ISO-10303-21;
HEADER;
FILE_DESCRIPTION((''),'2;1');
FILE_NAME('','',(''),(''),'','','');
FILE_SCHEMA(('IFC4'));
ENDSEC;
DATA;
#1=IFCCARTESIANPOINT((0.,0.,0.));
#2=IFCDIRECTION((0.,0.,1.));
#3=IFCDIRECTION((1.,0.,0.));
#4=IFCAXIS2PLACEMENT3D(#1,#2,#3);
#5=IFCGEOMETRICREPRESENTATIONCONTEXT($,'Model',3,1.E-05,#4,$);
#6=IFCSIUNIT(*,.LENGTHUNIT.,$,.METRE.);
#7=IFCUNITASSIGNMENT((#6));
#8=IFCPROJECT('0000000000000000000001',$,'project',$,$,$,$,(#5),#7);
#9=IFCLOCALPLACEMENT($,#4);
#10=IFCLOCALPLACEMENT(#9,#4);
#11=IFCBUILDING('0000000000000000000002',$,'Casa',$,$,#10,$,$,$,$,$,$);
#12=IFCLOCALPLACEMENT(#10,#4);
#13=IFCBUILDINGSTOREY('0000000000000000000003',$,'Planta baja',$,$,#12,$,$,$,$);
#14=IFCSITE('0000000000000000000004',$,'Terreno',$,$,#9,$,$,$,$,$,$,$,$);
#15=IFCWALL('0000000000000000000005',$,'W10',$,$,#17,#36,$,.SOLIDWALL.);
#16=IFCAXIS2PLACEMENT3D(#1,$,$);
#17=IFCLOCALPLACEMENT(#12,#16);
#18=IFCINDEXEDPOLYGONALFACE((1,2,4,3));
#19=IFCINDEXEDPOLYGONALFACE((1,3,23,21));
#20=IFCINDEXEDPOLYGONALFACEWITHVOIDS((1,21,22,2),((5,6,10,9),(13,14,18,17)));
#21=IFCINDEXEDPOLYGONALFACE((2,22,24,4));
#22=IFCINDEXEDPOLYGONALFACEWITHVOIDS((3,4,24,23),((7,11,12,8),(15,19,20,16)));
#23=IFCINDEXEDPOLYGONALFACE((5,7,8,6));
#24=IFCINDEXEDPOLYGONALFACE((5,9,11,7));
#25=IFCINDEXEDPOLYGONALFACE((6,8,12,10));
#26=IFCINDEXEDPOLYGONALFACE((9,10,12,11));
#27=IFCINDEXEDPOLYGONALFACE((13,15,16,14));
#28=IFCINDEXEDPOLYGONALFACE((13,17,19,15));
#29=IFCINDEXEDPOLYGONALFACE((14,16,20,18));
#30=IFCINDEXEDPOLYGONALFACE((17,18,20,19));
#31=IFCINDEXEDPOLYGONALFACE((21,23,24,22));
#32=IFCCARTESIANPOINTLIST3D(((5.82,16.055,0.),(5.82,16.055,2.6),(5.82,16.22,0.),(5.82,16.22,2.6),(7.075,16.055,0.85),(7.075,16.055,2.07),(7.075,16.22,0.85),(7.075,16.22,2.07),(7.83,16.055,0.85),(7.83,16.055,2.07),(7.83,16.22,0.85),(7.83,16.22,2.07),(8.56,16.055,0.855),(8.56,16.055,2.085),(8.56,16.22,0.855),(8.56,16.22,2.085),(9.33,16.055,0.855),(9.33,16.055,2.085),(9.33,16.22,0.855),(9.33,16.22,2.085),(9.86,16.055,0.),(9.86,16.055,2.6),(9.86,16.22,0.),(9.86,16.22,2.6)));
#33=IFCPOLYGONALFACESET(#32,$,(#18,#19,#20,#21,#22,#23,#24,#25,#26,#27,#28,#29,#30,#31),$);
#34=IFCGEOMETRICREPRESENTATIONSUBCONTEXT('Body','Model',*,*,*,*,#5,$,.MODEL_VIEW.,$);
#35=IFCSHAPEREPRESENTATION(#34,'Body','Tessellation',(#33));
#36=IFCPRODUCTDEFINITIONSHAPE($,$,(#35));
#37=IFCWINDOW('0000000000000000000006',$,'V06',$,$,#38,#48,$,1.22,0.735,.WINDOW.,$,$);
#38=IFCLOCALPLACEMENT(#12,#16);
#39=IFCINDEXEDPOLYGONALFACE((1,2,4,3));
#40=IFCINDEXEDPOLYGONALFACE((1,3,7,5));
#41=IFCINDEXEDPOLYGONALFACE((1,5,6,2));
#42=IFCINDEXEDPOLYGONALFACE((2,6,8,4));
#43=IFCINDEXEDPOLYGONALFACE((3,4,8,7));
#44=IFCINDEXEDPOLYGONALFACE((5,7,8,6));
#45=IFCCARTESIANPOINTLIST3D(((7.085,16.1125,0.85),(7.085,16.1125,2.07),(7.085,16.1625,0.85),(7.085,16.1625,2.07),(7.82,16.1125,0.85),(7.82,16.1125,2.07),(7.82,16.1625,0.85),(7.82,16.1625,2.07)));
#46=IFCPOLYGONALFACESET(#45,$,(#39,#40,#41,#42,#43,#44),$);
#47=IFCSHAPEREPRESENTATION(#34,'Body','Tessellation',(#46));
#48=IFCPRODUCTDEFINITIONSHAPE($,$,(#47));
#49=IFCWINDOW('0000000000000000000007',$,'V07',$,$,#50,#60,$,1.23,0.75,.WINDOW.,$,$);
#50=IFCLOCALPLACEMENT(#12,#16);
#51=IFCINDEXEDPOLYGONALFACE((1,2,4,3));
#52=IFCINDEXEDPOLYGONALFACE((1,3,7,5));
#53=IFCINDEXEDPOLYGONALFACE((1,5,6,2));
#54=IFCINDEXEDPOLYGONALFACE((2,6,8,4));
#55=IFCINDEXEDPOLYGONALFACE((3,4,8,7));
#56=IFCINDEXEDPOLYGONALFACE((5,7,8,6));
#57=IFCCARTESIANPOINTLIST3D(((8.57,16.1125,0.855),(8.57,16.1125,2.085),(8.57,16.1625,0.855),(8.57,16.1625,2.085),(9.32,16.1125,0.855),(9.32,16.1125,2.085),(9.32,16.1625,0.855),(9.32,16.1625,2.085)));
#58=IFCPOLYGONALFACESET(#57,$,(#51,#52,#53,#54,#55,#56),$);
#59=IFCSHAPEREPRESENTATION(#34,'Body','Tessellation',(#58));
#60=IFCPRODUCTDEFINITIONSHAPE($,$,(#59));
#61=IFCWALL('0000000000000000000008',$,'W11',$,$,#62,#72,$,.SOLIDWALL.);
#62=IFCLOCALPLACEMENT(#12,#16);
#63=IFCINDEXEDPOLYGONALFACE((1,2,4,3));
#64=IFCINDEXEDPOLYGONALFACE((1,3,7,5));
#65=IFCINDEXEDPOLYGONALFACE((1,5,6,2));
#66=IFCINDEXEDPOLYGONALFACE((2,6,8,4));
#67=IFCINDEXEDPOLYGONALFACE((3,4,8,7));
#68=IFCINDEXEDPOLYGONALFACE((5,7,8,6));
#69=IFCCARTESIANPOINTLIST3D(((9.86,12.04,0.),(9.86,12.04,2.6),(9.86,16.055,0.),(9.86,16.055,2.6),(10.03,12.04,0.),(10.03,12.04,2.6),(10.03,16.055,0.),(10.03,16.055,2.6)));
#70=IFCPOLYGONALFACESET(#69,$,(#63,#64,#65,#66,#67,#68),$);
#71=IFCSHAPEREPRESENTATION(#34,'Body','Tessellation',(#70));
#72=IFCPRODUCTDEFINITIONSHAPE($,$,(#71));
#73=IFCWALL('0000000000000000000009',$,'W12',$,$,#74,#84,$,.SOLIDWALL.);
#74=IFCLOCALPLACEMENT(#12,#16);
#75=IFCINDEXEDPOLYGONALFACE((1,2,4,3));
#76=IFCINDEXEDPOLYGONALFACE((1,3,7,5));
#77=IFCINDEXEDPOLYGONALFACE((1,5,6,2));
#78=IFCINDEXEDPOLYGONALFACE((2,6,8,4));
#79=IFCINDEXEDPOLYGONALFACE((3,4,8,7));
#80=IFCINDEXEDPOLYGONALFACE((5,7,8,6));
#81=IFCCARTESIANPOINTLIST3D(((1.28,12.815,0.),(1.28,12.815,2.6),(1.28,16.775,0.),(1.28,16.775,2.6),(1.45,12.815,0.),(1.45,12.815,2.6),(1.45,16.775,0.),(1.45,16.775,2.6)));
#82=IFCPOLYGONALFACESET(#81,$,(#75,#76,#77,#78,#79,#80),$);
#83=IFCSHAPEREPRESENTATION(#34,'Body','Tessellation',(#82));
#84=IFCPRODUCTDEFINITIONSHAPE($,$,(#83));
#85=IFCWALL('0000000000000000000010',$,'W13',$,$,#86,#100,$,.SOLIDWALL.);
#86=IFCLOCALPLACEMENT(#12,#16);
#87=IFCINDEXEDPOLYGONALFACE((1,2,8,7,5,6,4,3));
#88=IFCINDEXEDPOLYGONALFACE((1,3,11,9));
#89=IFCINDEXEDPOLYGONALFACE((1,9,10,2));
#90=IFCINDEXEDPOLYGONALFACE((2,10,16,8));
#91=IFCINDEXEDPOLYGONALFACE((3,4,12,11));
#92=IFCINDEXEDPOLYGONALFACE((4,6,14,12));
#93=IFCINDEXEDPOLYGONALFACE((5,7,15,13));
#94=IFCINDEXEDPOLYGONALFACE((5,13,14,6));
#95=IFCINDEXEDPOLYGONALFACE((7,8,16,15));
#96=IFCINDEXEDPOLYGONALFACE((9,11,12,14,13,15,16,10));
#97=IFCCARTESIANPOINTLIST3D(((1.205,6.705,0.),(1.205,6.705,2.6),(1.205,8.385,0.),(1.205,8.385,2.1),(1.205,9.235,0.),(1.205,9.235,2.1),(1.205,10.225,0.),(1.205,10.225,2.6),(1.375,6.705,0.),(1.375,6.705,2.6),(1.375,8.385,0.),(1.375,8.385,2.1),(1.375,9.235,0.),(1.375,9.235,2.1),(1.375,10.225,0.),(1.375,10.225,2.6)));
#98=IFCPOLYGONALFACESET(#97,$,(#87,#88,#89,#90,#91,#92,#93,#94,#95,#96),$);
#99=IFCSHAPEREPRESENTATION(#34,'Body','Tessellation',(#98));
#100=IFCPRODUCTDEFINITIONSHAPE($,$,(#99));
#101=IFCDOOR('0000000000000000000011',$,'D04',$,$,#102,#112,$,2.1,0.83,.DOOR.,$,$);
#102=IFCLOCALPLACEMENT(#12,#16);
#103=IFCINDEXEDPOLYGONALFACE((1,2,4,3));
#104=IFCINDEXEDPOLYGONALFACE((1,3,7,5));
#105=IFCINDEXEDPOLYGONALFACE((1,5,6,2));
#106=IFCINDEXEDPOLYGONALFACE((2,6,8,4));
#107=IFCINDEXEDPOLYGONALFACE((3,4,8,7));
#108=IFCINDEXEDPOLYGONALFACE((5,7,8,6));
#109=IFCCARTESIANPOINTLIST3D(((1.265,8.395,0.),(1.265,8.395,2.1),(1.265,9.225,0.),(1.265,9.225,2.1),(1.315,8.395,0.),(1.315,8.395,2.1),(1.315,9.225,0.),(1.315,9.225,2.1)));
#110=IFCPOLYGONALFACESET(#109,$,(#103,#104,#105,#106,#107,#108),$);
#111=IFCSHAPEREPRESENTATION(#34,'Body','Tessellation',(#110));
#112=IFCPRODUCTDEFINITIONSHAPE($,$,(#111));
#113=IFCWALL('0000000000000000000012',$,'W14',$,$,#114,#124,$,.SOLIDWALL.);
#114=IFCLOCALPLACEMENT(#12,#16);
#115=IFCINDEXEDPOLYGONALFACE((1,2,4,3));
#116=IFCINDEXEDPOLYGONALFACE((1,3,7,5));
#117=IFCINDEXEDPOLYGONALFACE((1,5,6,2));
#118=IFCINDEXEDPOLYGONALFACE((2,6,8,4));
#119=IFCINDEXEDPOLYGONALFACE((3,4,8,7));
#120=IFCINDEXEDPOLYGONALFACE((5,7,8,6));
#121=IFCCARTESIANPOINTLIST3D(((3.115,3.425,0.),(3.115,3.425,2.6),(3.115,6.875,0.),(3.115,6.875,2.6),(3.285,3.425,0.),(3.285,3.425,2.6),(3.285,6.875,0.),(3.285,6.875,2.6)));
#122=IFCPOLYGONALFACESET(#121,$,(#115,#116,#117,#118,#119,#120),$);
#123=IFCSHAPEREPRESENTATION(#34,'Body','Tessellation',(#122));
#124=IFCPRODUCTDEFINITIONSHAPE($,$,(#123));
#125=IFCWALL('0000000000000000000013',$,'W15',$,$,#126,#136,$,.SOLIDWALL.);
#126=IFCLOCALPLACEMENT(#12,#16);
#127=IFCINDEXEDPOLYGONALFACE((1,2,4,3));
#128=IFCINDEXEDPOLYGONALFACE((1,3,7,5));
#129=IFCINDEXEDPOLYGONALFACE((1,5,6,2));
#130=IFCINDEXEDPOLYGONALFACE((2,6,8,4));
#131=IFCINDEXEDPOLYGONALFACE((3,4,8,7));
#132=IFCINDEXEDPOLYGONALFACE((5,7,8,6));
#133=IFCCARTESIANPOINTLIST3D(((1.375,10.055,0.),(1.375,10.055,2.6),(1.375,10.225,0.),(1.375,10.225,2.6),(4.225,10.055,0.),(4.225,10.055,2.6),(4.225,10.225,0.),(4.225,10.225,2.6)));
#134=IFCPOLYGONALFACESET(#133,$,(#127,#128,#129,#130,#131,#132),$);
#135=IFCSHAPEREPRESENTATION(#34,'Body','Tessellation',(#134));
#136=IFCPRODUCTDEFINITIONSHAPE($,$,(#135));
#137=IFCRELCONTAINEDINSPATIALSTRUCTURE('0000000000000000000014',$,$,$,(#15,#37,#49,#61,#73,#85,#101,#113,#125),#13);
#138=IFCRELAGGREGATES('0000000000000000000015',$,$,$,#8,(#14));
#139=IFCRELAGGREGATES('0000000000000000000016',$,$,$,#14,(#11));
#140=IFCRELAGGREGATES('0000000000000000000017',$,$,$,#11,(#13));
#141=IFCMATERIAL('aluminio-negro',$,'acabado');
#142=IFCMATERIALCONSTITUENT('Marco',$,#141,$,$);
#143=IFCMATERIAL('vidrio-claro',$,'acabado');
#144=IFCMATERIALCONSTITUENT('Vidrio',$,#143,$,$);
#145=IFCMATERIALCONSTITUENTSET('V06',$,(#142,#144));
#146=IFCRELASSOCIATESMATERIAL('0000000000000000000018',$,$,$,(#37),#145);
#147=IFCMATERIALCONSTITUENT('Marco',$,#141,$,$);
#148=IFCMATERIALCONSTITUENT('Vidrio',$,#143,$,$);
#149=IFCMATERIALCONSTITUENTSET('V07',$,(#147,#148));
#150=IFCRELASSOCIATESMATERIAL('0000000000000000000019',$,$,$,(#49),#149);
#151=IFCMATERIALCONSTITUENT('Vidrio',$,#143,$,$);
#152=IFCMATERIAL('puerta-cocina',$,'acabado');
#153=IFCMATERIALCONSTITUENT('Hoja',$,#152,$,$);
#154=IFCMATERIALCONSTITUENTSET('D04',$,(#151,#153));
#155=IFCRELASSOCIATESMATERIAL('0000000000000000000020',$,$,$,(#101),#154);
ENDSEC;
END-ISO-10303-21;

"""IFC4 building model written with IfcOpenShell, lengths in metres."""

from ifc_helpers import new_model, si_unit, frame, origin_with_axes, place, context, subcontext, project, spatial, line, indexed_curve, outline, extrude, material, constituent, constituent_set, element, fill, save


model = new_model("IFC4")

# Units and contexts
model_context = context("Model", 3, precision=1e-05, world=origin_with_axes())
body_context = subcontext(model_context, "Body", "Model", "MODEL_VIEW")
ifc_project = project(units=[si_unit("LENGTHUNIT", "METRE")], contexts=[model_context])

# Site, building, storey
site_placement = place(None, origin_with_axes())
site = spatial("IfcSite", under=ifc_project, at=site_placement, Name="Terreno")
building_placement = place(site_placement, origin_with_axes())
building = spatial("IfcBuilding", under=site, at=building_placement, Name="Casa")
storey_placement = place(building_placement, origin_with_axes())
storey = spatial("IfcBuildingStorey", under=building, at=storey_placement, Name="Planta baja")

# Shared definitions
ifc_material_1 = material(Name="aluminio-negro", Category="acabado")
ifc_material_2 = material(Name="vidrio-claro", Category="acabado")

# Wall, openings, windows
wall_1_placement = place(storey_placement, origin_with_axes())
wall_1 = element("IfcWall", 1, at=wall_1_placement, inside=storey, Name="W10", PredefinedType="SOLIDWALL", context=body_context, shape_type="SweptSolid", body=[
    extrude(outline(indexed_curve([(5.82, 16.055), (5.82, 16.22), (9.86, 16.22), (9.86, 16.055)], segments=[line(1, 2, 3, 4, 1)])), origin_with_axes(), (0.0, 0.0, 1.0), 2.6),
])
opening_1_placement = place(wall_1_placement, origin_with_axes())
opening_1 = element("IfcOpeningElement", 2, at=opening_1_placement, cuts=wall_1, PredefinedType="OPENING", context=body_context, shape_type="SweptSolid", body=[
    extrude(outline(indexed_curve([(7.075, 16.045), (7.83, 16.045), (7.83, 16.23), (7.075, 16.23)], segments=[line(1, 2, 3, 4, 1)])), frame((0.0, 0.0, 0.85), z_axis=(0.0, 0.0, 1.0), x_axis=(1.0, 0.0, 0.0)), (0.0, 0.0, 1.0), 1.22),
])
opening_2_placement = place(wall_1_placement, origin_with_axes())
opening_2 = element("IfcOpeningElement", 3, at=opening_2_placement, cuts=wall_1, PredefinedType="OPENING", context=body_context, shape_type="SweptSolid", body=[
    extrude(outline(indexed_curve([(8.56, 16.045), (9.33, 16.045), (9.33, 16.23), (8.56, 16.23)], segments=[line(1, 2, 3, 4, 1)])), frame((0.0, 0.0, 0.855), z_axis=(0.0, 0.0, 1.0), x_axis=(1.0, 0.0, 0.0)), (0.0, 0.0, 1.0), 1.23),
])
ifc_constituent_1 = constituent(ifc_material_1, Name="Marco")
ifc_constituent_2 = constituent(ifc_material_2, Name="Vidrio")
ifc_constituent_set_1 = constituent_set(constituents=[ifc_constituent_1, ifc_constituent_2], Name="V06")
window_1_placement = place(opening_1_placement, origin_with_axes())
window_1 = element("IfcWindow", 4, at=window_1_placement, inside=storey, material=ifc_constituent_set_1, Name="V06", OverallHeight=1.22, OverallWidth=0.735, PredefinedType="WINDOW", context=body_context, shape_type="SweptSolid", body=[
    extrude(outline(indexed_curve([(7.085, 16.1125), (7.82, 16.1125), (7.82, 16.1625), (7.085, 16.1625)], segments=[line(1, 2, 3, 4, 1)])), frame((0.0, 0.0, 0.85), z_axis=(0.0, 0.0, 1.0), x_axis=(1.0, 0.0, 0.0)), (0.0, 0.0, 1.0), 1.22),
])
fill(opening_1, window_1)
ifc_constituent_3 = constituent(ifc_material_1, Name="Marco")
ifc_constituent_4 = constituent(ifc_material_2, Name="Vidrio")
ifc_constituent_set_2 = constituent_set(constituents=[ifc_constituent_3, ifc_constituent_4], Name="V07")
window_2_placement = place(opening_2_placement, origin_with_axes())
window_2 = element("IfcWindow", 5, at=window_2_placement, inside=storey, material=ifc_constituent_set_2, Name="V07", OverallHeight=1.23, OverallWidth=0.75, PredefinedType="WINDOW", context=body_context, shape_type="SweptSolid", body=[
    extrude(outline(indexed_curve([(8.57, 16.1125), (9.32, 16.1125), (9.32, 16.1625), (8.57, 16.1625)], segments=[line(1, 2, 3, 4, 1)])), frame((0.0, 0.0, 0.855), z_axis=(0.0, 0.0, 1.0), x_axis=(1.0, 0.0, 0.0)), (0.0, 0.0, 1.0), 1.23),
])
fill(opening_2, window_2)

# Walls
wall_2_placement = place(storey_placement, origin_with_axes())
element("IfcWall", 6, at=wall_2_placement, inside=storey, Name="W11", PredefinedType="SOLIDWALL", context=body_context, shape_type="SweptSolid", body=[
    extrude(outline(indexed_curve([(9.86, 12.04), (9.86, 16.055), (10.03, 16.055), (10.03, 12.04)], segments=[line(1, 2, 3, 4, 1)])), origin_with_axes(), (0.0, 0.0, 1.0), 2.6),
])
wall_3_placement = place(storey_placement, origin_with_axes())
element("IfcWall", 7, at=wall_3_placement, inside=storey, Name="W12", PredefinedType="SOLIDWALL", context=body_context, shape_type="SweptSolid", body=[
    extrude(outline(indexed_curve([(1.28, 16.775), (1.45, 16.775), (1.45, 12.815), (1.28, 12.815)], segments=[line(1, 2, 3, 4, 1)])), origin_with_axes(), (0.0, 0.0, 1.0), 2.6),
])

# Wall, opening, door
wall_4_placement = place(storey_placement, origin_with_axes())
wall_4 = element("IfcWall", 8, at=wall_4_placement, inside=storey, Name="W13", PredefinedType="SOLIDWALL", context=body_context, shape_type="SweptSolid", body=[
    extrude(outline(indexed_curve([(1.375, 6.705), (1.205, 6.705), (1.205, 10.225), (1.375, 10.225)], segments=[line(1, 2, 3, 4, 1)])), origin_with_axes(), (0.0, 0.0, 1.0), 2.6),
])
opening_3_placement = place(wall_4_placement, origin_with_axes())
opening_3 = element("IfcOpeningElement", 9, at=opening_3_placement, cuts=wall_4, PredefinedType="OPENING", context=body_context, shape_type="SweptSolid", body=[
    extrude(outline(indexed_curve([(1.195, 8.385), (1.195, 9.235), (1.385, 9.235), (1.385, 8.385)], segments=[line(1, 2, 3, 4, 1)])), origin_with_axes(), (0.0, 0.0, 1.0), 2.1),
])
ifc_constituent_5 = constituent(ifc_material_2, Name="Vidrio")
ifc_material_3 = material(Name="puerta-cocina", Category="acabado")
ifc_constituent_6 = constituent(ifc_material_3, Name="Hoja")
ifc_constituent_set_3 = constituent_set(constituents=[ifc_constituent_5, ifc_constituent_6], Name="D04")
door_1_placement = place(opening_3_placement, origin_with_axes())
door_1 = element("IfcDoor", 10, at=door_1_placement, inside=storey, material=ifc_constituent_set_3, Name="D04", OverallHeight=2.1, OverallWidth=0.83, PredefinedType="DOOR", context=body_context, shape_type="SweptSolid", body=[
    extrude(outline(indexed_curve([(1.265, 8.395), (1.265, 9.225), (1.315, 9.225), (1.315, 8.395)], segments=[line(1, 2, 3, 4, 1)])), origin_with_axes(), (0.0, 0.0, 1.0), 2.1),
])
fill(opening_3, door_1)

# Walls
wall_5_placement = place(storey_placement, origin_with_axes())
element("IfcWall", 11, at=wall_5_placement, inside=storey, Name="W14", PredefinedType="SOLIDWALL", context=body_context, shape_type="SweptSolid", body=[
    extrude(outline(indexed_curve([(3.285, 3.425), (3.115, 3.425), (3.115, 6.875), (3.285, 6.875)], segments=[line(1, 2, 3, 4, 1)])), origin_with_axes(), (0.0, 0.0, 1.0), 2.6),
])
wall_6_placement = place(storey_placement, origin_with_axes())
element("IfcWall", 12, at=wall_6_placement, inside=storey, Name="W15", PredefinedType="SOLIDWALL", context=body_context, shape_type="SweptSolid", body=[
    extrude(outline(indexed_curve([(4.225, 10.225), (4.225, 10.055), (1.375, 10.055), (1.375, 10.225)], segments=[line(1, 2, 3, 4, 1)])), origin_with_axes(), (0.0, 0.0, 1.0), 2.6),
])

save(model, "model.ifc")
